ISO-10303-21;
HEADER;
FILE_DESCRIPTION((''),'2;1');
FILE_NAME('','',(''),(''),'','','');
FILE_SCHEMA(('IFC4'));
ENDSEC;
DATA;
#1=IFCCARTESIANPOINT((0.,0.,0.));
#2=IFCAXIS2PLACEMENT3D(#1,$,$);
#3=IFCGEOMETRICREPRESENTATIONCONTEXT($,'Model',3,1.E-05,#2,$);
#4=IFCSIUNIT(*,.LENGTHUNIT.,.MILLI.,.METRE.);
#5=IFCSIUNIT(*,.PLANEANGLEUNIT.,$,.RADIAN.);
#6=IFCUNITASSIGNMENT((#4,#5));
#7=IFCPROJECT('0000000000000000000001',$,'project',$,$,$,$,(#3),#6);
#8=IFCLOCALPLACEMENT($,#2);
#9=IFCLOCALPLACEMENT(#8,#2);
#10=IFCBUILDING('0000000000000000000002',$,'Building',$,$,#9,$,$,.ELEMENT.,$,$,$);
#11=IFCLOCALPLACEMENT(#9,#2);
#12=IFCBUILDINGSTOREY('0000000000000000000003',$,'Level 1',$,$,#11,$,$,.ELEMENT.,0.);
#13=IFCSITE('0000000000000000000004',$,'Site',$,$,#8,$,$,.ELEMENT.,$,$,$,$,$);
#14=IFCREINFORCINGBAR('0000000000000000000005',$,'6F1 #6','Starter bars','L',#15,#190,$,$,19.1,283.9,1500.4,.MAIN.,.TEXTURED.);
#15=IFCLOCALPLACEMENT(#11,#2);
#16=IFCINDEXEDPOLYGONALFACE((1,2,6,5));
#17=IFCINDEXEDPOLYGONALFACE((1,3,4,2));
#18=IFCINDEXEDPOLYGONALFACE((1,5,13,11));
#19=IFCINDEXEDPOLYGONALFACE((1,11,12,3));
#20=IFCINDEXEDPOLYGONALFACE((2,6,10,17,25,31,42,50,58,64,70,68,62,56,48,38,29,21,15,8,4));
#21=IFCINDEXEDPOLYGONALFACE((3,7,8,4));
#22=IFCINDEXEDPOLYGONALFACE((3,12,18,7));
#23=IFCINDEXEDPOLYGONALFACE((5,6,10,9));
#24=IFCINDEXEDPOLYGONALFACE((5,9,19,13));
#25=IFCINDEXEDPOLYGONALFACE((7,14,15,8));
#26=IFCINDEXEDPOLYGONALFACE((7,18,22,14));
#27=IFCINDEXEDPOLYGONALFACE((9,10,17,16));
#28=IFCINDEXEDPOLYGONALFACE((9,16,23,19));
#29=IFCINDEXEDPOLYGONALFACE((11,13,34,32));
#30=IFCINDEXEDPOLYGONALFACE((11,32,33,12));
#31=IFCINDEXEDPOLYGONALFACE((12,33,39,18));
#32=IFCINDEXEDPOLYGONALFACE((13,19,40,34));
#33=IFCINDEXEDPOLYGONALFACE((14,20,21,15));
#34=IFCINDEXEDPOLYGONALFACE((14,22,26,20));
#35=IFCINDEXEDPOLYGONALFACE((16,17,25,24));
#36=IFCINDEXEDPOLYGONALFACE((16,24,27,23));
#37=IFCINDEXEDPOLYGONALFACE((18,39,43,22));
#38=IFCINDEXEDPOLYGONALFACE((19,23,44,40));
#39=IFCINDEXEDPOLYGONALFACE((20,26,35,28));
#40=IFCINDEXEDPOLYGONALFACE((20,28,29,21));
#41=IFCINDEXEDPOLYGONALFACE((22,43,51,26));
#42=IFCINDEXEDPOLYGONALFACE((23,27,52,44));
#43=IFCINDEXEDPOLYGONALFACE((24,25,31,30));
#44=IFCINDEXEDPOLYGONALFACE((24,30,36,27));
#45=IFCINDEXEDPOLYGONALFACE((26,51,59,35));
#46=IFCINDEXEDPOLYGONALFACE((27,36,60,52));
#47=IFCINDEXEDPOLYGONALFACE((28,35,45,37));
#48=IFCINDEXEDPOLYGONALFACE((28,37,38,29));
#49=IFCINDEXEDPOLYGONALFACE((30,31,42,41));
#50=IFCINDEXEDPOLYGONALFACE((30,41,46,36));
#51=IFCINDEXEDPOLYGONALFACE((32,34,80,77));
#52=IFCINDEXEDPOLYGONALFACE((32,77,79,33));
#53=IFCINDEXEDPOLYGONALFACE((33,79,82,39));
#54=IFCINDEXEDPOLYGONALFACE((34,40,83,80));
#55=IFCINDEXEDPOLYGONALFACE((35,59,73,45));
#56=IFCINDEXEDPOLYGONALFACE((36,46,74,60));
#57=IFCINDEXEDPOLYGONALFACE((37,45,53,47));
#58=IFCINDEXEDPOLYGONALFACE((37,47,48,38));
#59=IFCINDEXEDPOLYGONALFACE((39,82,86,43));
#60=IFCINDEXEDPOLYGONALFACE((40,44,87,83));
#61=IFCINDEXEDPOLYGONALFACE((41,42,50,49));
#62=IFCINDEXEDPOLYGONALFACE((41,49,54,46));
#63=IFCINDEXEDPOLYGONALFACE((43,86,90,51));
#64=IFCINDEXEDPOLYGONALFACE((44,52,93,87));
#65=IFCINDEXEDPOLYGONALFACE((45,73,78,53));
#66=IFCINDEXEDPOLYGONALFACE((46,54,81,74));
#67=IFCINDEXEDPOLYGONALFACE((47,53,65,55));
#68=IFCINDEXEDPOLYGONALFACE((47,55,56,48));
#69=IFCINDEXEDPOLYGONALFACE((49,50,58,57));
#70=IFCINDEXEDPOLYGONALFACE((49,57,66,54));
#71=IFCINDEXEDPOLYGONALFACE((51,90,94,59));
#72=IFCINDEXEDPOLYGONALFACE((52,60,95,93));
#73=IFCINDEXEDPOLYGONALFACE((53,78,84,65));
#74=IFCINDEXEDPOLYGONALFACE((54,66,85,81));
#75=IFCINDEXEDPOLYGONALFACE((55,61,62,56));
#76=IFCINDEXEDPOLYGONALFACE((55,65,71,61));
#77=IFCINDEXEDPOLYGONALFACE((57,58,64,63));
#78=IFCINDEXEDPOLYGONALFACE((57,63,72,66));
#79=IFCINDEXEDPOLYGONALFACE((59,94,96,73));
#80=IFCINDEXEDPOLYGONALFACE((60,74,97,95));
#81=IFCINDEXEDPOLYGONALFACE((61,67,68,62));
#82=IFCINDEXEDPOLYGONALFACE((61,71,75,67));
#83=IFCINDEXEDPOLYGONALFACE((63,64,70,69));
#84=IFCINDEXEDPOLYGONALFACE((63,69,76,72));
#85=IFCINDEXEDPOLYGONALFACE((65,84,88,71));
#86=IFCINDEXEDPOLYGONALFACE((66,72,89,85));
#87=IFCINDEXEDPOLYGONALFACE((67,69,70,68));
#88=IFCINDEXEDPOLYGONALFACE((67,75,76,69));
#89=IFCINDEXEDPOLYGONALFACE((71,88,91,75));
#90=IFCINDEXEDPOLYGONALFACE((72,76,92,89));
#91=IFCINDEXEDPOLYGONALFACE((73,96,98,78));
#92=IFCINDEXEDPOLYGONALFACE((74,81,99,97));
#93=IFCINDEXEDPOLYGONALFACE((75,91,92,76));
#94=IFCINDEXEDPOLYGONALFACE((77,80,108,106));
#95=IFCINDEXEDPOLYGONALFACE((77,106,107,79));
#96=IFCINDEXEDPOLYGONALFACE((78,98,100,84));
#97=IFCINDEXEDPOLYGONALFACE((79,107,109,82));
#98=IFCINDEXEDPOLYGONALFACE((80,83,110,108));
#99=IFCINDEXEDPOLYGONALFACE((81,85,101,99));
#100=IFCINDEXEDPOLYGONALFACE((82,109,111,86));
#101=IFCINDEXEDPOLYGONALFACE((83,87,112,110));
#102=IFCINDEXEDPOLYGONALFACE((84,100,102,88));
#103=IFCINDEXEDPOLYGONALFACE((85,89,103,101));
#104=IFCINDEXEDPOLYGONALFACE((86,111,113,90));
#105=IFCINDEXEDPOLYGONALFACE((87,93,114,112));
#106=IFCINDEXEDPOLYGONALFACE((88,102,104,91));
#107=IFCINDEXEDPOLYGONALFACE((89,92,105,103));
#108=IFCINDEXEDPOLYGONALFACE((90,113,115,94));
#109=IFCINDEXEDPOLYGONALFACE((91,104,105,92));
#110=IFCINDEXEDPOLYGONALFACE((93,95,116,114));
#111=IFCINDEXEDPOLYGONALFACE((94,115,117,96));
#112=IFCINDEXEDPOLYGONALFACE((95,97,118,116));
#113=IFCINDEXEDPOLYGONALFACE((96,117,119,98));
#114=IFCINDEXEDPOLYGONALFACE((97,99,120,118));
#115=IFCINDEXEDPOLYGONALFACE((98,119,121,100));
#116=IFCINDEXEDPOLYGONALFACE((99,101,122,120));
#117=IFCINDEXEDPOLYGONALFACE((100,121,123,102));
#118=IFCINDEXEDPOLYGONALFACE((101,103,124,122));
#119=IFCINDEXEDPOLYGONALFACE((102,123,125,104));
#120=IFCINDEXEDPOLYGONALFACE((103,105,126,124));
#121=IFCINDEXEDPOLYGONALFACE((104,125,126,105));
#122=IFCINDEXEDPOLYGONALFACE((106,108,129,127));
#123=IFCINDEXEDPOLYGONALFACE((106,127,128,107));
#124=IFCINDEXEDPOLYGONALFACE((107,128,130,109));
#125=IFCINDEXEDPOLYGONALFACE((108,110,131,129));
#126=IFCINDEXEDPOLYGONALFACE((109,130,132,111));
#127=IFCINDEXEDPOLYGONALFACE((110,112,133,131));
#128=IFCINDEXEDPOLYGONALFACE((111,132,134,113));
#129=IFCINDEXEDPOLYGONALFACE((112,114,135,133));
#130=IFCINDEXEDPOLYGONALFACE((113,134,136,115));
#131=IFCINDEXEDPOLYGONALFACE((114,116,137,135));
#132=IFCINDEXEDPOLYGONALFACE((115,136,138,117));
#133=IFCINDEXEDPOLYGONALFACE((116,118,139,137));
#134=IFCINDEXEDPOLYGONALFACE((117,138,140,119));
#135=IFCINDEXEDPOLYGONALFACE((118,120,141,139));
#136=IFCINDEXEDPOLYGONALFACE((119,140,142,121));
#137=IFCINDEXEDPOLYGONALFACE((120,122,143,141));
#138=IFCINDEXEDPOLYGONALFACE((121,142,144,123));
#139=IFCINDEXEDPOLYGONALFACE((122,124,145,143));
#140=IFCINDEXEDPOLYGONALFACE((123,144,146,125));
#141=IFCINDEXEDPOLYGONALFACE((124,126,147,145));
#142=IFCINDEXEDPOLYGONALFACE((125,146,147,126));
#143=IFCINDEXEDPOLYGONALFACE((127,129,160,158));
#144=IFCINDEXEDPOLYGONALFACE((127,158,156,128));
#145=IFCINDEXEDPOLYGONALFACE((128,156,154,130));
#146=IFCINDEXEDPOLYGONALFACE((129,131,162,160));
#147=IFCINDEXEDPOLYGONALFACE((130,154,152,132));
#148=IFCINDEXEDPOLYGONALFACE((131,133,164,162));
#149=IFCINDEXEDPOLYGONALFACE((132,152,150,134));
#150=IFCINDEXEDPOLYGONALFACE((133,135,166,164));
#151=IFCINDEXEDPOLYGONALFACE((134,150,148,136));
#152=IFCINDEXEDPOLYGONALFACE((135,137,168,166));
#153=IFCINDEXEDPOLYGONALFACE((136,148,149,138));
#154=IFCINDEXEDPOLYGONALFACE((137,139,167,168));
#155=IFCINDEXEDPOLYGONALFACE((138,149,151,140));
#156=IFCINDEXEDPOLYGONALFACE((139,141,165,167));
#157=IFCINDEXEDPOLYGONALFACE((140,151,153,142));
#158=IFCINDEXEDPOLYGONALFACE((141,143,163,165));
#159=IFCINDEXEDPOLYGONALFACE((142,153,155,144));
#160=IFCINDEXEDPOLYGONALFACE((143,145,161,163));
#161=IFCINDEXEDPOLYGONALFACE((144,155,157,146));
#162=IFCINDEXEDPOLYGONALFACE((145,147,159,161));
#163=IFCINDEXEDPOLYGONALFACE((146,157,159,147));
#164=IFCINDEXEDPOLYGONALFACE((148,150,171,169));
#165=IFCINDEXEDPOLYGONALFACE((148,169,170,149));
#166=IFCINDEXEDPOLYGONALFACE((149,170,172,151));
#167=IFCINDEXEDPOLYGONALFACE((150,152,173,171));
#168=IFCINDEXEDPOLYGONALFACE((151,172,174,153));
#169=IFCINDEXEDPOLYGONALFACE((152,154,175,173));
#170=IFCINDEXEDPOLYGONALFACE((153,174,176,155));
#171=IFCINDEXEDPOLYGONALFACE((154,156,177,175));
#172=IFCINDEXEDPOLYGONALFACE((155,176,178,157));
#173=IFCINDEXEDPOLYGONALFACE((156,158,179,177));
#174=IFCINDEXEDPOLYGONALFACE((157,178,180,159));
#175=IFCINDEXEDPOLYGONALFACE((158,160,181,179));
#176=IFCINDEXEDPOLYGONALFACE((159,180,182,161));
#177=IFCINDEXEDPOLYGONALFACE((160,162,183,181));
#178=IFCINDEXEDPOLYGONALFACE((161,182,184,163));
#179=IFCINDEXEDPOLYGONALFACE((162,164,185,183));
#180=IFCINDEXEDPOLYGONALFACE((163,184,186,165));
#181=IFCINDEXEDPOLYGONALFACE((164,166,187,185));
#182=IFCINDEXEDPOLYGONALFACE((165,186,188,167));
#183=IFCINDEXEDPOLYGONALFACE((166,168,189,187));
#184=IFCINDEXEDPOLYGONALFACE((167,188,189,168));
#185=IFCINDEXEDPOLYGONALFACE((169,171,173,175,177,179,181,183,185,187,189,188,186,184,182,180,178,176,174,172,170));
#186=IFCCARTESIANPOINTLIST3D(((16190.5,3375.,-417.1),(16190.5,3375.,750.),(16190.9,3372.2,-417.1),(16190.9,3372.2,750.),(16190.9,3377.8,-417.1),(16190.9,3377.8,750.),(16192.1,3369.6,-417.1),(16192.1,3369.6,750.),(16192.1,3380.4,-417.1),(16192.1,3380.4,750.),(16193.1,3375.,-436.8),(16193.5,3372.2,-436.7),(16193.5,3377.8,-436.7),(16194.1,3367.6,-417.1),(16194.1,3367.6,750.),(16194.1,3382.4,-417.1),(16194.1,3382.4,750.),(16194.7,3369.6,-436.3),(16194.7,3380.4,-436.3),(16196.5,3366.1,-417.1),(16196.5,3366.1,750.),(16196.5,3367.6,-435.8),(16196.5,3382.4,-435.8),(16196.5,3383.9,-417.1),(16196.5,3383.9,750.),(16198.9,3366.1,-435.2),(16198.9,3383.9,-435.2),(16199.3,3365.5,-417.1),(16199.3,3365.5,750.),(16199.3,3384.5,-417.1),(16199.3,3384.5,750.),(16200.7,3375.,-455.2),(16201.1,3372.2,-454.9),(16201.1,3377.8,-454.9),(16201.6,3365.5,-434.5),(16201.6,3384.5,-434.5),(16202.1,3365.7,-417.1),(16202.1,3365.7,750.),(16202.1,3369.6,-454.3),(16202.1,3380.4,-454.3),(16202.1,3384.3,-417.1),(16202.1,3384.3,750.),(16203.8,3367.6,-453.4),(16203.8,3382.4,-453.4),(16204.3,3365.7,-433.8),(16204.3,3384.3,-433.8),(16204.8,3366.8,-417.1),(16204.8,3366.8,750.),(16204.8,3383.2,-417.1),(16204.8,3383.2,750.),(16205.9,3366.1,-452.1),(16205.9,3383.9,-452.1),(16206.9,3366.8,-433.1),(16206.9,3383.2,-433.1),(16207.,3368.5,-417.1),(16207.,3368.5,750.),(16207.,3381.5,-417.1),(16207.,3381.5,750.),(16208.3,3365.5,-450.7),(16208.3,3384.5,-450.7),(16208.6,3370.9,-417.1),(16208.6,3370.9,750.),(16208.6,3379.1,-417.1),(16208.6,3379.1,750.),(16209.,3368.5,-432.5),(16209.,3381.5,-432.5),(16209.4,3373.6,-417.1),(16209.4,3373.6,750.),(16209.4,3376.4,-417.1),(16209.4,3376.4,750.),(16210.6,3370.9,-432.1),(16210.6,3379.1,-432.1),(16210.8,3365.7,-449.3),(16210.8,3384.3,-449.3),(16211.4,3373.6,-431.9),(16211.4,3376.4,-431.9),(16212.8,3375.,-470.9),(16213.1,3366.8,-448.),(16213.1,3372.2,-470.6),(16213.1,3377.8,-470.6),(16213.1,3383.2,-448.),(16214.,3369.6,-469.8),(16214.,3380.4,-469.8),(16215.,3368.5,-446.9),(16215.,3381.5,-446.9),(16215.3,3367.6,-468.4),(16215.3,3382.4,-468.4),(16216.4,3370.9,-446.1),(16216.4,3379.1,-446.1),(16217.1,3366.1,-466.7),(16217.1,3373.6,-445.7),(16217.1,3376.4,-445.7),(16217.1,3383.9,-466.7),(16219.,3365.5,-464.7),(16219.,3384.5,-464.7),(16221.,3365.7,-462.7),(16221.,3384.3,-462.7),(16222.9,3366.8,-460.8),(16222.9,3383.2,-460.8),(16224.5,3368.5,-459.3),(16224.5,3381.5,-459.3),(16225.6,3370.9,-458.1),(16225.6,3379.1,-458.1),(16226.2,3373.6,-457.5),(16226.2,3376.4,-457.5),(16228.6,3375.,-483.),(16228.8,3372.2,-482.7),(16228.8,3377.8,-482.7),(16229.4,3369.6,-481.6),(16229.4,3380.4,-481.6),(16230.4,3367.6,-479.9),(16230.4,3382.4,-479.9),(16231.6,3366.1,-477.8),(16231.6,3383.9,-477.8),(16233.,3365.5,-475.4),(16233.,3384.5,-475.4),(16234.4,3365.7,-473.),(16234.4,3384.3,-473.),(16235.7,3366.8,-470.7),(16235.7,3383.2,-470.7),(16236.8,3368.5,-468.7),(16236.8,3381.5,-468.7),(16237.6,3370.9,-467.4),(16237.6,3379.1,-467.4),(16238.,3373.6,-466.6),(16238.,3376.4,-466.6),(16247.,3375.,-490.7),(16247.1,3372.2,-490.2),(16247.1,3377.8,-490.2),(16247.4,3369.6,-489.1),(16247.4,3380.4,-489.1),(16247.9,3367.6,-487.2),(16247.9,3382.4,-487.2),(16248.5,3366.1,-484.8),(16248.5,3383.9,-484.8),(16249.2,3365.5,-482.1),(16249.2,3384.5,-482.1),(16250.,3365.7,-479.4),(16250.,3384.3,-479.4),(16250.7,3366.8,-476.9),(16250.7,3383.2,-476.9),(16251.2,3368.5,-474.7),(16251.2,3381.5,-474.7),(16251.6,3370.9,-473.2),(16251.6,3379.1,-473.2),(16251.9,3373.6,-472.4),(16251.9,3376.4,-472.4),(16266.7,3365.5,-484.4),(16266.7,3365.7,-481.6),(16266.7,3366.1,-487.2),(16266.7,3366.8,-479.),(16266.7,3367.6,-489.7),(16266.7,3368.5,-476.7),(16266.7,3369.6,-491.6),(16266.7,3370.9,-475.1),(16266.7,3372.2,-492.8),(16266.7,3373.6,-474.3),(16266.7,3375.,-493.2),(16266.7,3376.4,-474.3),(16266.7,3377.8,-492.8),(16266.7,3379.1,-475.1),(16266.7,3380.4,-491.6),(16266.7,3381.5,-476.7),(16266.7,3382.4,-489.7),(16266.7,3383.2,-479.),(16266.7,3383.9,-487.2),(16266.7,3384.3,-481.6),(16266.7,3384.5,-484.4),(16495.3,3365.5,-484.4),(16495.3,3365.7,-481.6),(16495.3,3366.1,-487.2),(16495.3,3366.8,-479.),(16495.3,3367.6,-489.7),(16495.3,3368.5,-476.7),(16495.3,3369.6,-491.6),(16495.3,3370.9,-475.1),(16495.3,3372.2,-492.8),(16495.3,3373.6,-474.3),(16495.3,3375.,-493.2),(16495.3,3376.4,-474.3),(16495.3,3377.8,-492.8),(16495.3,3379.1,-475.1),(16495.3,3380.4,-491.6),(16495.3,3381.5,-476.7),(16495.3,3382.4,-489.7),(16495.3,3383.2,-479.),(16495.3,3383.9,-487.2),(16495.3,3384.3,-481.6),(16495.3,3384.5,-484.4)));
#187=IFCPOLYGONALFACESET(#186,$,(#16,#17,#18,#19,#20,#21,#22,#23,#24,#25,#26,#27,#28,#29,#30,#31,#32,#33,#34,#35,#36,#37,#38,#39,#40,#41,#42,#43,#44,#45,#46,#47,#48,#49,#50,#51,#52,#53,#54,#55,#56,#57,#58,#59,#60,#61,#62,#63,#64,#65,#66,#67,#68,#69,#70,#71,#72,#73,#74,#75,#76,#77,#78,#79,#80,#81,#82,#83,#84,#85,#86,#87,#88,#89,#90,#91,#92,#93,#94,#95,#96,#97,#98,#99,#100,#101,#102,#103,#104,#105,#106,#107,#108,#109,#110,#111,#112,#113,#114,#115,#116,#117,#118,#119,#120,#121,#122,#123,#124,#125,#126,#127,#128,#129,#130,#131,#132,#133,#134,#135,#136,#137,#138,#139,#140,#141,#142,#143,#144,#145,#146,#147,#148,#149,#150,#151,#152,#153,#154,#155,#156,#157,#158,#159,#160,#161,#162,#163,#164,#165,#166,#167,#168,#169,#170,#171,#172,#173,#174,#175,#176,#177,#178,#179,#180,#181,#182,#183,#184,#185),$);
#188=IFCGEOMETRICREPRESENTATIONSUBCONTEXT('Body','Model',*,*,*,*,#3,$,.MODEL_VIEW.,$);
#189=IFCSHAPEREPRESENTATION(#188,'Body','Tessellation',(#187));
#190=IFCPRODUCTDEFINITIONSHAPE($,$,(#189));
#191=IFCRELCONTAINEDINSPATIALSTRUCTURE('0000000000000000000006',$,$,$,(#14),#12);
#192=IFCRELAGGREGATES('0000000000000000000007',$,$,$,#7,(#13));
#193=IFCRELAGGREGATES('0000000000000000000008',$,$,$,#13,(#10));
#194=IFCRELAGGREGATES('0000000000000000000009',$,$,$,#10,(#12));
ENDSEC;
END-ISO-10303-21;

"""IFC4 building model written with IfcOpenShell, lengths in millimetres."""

from ifc_helpers import new_model, entity, si_unit, origin, place, context, subcontext, project, spatial, element, save


model = new_model("IFC4")

# Units and contexts
model_context = context("Model", 3, precision=1e-05, world=origin())
body_context = subcontext(model_context, "Body", "Model", "MODEL_VIEW")
ifc_project = project(units=[si_unit("LENGTHUNIT", "METRE", prefix="MILLI"), si_unit("PLANEANGLEUNIT", "RADIAN")], contexts=[model_context])

# Site, building, storey
site_placement = place(None, origin())
site = spatial("IfcSite", under=ifc_project, at=site_placement, Name="Site", CompositionType="ELEMENT")
building_placement = place(site_placement, origin())
building = spatial("IfcBuilding", under=site, at=building_placement, Name="Building", CompositionType="ELEMENT")
storey_placement = place(building_placement, origin())
storey = spatial("IfcBuildingStorey", under=building, at=storey_placement, Name="Level 1", CompositionType="ELEMENT", Elevation=0.0)

# Reinforcing bar
reinforcing_bar_1_placement = place(storey_placement, origin())
element("IfcReinforcingBar", 1, at=reinforcing_bar_1_placement, inside=storey, Name="6F1 #6", Description="Starter bars", ObjectType="L", BarLength=1500.4, BarSurface="TEXTURED", CrossSectionArea=283.9, NominalDiameter=19.1, PredefinedType="MAIN", context=body_context, shape_type="AdvancedSweptSolid", body=[
    entity("IfcSweptDiskSolid", entity("IfcIndexedPolyCurve", entity("IfcCartesianPointList3D", [[16200.0, 3375.0, 750.0], [16200.0, 3375.0, -417.1], [16219.5, 3375.0, -464.2], [16266.7, 3375.0, -483.7], [16495.3, 3375.0, -483.7]]), [entity("IfcLineIndex", [1, 2]), entity("IfcArcIndex", [2, 3, 4]), entity("IfcLineIndex", [4, 5])], False), 9.5),
])

save(model, "model.ifc")
